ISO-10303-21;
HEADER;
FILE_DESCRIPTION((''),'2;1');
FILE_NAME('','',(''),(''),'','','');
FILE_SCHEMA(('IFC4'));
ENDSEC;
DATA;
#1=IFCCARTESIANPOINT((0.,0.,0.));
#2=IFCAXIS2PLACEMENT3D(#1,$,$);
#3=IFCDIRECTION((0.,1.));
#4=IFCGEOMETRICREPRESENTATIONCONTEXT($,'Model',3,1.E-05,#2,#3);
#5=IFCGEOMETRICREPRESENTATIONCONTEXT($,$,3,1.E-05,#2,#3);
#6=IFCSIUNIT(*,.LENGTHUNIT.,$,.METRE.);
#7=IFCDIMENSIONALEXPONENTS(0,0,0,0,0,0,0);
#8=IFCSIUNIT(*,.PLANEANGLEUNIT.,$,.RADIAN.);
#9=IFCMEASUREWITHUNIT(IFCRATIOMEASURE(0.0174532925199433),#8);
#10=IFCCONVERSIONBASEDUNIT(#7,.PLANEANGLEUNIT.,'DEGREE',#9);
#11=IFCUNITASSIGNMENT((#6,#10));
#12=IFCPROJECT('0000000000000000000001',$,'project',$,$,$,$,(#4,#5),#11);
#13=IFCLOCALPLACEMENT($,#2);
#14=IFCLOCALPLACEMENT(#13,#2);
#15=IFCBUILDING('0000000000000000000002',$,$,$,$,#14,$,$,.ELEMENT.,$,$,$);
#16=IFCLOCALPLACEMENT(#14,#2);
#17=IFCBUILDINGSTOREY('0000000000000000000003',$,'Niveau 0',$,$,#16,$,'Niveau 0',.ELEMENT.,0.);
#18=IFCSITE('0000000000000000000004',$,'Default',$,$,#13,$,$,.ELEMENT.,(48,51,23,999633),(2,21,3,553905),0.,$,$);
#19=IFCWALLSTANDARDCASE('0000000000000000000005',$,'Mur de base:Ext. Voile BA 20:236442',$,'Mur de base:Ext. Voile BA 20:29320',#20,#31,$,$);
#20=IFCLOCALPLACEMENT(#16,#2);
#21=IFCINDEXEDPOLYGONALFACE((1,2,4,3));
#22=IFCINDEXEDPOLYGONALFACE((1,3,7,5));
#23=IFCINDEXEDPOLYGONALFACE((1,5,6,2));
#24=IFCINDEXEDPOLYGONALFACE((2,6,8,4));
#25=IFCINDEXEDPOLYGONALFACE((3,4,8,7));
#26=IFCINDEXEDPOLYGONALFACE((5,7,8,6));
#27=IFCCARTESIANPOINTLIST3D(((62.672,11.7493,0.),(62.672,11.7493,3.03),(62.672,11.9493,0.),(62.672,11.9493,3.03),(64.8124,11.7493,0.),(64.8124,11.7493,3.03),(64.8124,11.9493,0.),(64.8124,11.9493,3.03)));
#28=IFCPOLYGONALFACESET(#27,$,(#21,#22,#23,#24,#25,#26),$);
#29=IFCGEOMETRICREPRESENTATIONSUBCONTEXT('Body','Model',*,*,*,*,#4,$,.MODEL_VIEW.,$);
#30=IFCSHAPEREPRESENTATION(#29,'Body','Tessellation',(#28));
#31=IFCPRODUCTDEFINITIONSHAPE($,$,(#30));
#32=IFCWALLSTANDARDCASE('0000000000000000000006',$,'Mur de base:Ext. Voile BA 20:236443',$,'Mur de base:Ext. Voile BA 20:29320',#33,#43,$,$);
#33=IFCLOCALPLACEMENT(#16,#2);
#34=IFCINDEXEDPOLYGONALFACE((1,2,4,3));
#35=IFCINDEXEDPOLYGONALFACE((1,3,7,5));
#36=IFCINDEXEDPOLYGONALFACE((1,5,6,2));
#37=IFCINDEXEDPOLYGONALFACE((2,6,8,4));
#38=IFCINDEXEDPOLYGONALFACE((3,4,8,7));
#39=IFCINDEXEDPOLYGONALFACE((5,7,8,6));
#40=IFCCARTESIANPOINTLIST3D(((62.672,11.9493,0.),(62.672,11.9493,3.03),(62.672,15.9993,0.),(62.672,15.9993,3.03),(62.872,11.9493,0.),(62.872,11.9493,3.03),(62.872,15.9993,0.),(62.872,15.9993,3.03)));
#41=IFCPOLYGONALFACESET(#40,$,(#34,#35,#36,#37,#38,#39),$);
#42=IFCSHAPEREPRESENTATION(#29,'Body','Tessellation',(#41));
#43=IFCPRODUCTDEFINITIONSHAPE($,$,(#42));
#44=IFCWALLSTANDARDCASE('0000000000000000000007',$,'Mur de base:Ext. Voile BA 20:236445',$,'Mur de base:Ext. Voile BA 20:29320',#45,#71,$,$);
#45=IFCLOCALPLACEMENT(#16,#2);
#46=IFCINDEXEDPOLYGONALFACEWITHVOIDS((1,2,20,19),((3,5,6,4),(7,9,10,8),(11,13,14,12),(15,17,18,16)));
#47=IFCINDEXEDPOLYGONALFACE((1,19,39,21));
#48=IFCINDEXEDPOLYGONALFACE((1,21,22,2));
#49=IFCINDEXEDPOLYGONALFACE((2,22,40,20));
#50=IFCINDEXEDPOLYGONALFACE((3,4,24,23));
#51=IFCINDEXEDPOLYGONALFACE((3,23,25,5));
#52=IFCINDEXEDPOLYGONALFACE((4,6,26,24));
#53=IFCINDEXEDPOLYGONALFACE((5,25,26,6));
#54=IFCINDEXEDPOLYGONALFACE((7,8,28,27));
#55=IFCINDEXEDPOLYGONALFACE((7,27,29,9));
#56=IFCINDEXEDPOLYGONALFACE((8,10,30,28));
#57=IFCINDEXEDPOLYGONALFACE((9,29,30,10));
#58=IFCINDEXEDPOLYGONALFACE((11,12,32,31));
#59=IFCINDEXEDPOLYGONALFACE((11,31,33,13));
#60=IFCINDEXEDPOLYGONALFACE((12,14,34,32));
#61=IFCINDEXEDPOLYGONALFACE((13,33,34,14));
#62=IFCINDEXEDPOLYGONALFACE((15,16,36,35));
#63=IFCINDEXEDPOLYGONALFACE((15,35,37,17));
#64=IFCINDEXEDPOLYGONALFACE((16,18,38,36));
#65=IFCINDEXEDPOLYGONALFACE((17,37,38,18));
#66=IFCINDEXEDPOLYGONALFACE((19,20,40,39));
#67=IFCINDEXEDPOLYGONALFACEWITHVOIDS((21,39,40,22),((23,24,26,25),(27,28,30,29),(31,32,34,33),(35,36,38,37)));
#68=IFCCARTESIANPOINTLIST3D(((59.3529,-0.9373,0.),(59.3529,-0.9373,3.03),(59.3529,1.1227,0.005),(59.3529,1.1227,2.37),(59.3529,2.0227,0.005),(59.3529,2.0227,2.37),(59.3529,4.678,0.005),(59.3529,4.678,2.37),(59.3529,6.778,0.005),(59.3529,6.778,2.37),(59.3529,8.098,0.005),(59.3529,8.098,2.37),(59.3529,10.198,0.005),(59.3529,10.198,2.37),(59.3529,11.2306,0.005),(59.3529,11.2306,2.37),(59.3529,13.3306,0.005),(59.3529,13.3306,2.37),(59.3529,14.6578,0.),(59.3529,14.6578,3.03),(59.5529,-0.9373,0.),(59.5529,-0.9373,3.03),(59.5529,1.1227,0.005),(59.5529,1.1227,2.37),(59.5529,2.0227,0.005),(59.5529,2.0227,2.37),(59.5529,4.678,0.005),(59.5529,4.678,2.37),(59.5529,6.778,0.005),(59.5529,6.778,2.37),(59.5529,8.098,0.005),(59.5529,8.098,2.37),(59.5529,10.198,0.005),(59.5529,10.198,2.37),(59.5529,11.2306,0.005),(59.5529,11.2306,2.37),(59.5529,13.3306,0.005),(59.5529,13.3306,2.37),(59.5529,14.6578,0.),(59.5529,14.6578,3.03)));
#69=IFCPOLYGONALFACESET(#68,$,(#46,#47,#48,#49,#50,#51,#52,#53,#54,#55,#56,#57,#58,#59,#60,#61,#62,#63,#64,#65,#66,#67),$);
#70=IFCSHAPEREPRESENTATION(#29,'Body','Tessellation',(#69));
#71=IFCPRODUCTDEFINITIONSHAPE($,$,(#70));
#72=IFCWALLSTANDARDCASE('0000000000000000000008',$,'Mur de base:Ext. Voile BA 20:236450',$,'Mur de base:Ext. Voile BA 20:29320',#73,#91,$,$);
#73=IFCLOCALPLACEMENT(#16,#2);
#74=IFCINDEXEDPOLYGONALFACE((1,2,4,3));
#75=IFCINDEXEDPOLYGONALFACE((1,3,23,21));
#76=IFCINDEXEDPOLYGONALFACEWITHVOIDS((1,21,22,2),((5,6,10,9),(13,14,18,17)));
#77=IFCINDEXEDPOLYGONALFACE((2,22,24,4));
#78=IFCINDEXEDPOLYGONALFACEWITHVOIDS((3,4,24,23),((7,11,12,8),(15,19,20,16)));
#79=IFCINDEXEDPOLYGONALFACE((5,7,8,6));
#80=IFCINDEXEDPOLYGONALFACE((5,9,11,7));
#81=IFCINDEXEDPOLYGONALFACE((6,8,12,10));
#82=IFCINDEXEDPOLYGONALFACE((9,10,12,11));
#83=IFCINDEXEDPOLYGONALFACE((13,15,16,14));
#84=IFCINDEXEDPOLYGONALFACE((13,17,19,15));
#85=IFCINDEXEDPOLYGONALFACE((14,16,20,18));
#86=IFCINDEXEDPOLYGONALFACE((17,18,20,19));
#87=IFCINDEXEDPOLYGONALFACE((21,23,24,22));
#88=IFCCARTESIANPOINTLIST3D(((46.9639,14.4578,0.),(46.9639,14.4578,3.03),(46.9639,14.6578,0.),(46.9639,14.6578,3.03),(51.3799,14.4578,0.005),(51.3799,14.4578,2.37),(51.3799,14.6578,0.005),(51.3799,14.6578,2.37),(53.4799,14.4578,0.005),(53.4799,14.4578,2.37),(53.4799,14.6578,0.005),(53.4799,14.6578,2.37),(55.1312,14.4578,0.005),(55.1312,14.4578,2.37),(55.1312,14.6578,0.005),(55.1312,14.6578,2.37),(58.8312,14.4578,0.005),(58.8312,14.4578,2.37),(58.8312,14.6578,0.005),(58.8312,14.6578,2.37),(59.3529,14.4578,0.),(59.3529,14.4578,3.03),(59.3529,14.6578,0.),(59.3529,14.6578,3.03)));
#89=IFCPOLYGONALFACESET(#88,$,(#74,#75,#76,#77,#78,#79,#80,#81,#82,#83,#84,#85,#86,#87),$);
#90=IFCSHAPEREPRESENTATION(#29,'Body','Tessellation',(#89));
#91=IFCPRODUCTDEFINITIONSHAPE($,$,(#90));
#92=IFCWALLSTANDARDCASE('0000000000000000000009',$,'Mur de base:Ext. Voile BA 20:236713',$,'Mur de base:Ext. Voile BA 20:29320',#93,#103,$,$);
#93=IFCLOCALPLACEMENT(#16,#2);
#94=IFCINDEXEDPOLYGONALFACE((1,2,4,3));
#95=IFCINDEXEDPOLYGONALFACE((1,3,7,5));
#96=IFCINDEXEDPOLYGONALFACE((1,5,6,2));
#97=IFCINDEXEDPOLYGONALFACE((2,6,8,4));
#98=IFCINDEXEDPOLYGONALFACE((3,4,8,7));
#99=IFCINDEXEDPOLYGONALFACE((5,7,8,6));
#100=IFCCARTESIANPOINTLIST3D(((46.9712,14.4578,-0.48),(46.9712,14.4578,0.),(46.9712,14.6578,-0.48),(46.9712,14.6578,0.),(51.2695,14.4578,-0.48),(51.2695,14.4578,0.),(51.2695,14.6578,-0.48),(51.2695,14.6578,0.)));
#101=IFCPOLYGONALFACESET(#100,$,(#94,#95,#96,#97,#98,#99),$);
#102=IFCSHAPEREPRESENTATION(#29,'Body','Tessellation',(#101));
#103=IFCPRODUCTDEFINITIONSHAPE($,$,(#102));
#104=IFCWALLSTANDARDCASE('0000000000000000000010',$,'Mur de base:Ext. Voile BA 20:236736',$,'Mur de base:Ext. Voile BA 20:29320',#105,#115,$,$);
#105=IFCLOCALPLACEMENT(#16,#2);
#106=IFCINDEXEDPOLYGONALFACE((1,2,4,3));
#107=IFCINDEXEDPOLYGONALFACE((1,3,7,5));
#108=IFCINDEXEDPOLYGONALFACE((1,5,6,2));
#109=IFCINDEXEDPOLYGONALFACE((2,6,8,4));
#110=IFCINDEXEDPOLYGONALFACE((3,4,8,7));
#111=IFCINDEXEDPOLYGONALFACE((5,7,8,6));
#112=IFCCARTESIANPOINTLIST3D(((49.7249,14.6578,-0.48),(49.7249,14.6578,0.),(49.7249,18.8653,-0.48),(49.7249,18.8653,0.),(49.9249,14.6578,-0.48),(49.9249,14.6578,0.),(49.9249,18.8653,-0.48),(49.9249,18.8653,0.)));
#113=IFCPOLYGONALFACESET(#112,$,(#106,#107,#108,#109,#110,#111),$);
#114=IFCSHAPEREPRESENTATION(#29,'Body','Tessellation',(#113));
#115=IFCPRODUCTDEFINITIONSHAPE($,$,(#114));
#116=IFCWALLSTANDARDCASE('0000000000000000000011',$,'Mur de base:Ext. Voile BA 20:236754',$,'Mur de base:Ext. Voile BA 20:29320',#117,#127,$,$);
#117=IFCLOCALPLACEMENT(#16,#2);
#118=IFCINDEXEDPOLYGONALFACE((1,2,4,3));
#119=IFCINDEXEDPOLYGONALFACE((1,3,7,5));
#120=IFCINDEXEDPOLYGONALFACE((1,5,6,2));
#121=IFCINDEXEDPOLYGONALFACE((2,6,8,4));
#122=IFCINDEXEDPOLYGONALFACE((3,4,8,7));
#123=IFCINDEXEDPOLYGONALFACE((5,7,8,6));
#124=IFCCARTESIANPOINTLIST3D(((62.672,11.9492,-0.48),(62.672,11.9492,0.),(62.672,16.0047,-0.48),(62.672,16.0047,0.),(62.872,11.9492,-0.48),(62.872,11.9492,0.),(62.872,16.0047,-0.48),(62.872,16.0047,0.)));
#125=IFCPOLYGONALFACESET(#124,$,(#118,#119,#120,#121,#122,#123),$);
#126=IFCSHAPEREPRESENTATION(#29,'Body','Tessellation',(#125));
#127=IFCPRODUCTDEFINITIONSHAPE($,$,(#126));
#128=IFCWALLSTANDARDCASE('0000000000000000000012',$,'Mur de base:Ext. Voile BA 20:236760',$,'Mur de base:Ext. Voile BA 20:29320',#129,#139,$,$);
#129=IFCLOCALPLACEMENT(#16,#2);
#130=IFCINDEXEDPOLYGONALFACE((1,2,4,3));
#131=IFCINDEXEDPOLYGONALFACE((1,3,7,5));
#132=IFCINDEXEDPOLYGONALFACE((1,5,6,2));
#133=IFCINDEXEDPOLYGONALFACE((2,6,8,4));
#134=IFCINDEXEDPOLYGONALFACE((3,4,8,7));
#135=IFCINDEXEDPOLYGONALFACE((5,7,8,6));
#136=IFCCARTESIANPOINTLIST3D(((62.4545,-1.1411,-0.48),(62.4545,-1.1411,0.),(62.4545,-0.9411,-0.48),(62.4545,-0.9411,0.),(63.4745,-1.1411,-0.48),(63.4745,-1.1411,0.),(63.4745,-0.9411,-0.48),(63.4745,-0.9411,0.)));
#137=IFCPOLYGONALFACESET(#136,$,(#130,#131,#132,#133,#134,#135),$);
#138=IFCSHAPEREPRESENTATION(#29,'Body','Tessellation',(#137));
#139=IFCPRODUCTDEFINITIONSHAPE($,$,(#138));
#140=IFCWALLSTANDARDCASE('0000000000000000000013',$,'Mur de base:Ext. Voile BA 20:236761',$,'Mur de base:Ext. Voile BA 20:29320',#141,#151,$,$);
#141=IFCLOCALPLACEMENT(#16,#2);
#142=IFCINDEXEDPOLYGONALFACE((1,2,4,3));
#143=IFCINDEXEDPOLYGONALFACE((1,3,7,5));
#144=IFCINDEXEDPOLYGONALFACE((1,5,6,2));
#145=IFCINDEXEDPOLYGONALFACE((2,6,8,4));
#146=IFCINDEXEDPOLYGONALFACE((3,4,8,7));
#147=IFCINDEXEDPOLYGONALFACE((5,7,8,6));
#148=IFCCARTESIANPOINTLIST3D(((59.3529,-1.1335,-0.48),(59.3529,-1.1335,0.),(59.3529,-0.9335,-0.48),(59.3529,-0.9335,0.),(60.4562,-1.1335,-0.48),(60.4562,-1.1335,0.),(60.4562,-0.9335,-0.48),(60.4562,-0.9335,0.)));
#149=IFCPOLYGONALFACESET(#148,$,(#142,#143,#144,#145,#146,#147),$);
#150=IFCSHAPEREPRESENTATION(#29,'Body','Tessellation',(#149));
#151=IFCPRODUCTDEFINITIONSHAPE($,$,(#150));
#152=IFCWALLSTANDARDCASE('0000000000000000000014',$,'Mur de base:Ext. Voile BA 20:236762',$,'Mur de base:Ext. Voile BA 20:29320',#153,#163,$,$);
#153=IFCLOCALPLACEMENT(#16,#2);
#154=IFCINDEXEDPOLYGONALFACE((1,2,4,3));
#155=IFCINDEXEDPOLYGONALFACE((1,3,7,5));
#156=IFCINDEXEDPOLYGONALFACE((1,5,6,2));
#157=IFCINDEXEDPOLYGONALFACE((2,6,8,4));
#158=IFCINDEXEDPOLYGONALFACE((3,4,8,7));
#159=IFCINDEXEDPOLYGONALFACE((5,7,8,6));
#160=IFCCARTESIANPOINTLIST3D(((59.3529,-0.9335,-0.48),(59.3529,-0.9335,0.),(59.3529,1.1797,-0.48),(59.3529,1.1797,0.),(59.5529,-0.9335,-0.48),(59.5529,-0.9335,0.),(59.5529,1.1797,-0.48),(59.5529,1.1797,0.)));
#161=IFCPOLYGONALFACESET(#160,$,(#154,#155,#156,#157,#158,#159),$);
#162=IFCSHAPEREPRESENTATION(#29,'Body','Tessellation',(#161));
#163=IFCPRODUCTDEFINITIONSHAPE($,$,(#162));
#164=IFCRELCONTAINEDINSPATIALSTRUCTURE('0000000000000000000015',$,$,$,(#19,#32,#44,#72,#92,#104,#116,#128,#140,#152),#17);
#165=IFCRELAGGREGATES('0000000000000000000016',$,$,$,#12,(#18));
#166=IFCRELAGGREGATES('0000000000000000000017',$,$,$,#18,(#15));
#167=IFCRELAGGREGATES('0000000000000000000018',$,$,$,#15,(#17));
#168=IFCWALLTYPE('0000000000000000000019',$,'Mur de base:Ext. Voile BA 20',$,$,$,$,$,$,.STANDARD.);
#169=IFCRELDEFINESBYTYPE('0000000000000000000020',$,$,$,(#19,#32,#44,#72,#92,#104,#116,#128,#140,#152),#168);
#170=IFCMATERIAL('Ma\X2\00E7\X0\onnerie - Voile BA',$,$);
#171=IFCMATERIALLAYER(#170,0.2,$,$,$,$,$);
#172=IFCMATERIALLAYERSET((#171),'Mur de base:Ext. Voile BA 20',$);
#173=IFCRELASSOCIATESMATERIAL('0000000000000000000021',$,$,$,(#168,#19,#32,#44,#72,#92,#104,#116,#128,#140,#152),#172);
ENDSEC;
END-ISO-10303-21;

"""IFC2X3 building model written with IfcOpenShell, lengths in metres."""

from ifc_helpers import new_model, entity, si_unit, converted_unit, direction, frame, frame_2d, origin, origin_2d_with_axis, place, context, subcontext, project, spatial, rectangle, extrude, material, layer, layer_set, layer_usage, type_object, element, save


model = new_model("IFC2X3")

# Units and contexts
model_context = context("Model", 3, precision=1e-05, world=origin(), true_north=direction((0.0, 1.0)))
context_of_model = context(None, 3, precision=1e-05, world=origin(), true_north=direction((0.0, 1.0)))
body_context = subcontext(model_context, "Body", "Model", "MODEL_VIEW")
ifc_project = project(units=[si_unit("LENGTHUNIT", "METRE"), converted_unit("PLANEANGLEUNIT", "DEGREE", entity("IfcRatioMeasure", 0.0174532925199433), si_unit("PLANEANGLEUNIT", "RADIAN"), dimensions=[0, 0, 0, 0, 0, 0, 0])], contexts=[model_context, context_of_model])

# Site, building, storey
site_placement = place(None, origin())
site = spatial("IfcSite", under=ifc_project, at=site_placement, Name="Default", CompositionType="ELEMENT", RefLatitude=(48, 51, 23, 999633), RefLongitude=(2, 21, 3, 553905), RefElevation=0.0)
building_placement = place(site_placement, origin())
building = spatial("IfcBuilding", under=site, at=building_placement, CompositionType="ELEMENT")
storey_placement = place(building_placement, origin())
storey = spatial("IfcBuildingStorey", under=building, at=storey_placement, Name="Niveau 0", LongName="Niveau 0", CompositionType="ELEMENT", Elevation=0.0)

# Walls
ifc_material = material(Name="Maçonnerie - Voile BA")
ifc_layer = layer(ifc_material, 0.2)
ifc_layer_set = layer_set([ifc_layer], Name="Mur de base:Ext. Voile BA 20")
ifc_layer_usage_1 = layer_usage(ifc_layer_set, "AXIS2", "NEGATIVE", 0.1)
wall_type = type_object("IfcWallType", Name="Mur de base:Ext. Voile BA 20", PredefinedType="STANDARD", material=ifc_layer_set)
wall_1_placement = place(storey_placement, frame((64.8124, 11.8493, 0.0), z_axis=(0.0, 0.0, 1.0), x_axis=(-1.0, 0.0, 0.0)))
element("IfcWallStandardCase", 1, at=wall_1_placement, inside=storey, type_object=wall_type, material=ifc_layer_usage_1, Name="Mur de base:Ext. Voile BA 20:236442", ObjectType="Mur de base:Ext. Voile BA 20:29320", context=body_context, shape_type="SweptSolid", body=[
    extrude(rectangle(XDim=2.1404, YDim=0.2, at=frame_2d((1.0702, 0.0), x_axis=(-1.0, 0.0))), origin(), (0.0, 0.0, 1.0), 3.03),
])
ifc_layer_usage_2 = layer_usage(ifc_layer_set, "AXIS2", "NEGATIVE", 0.1)
wall_2_placement = place(storey_placement, frame((62.772, 11.9493, 0.0), z_axis=(0.0, 0.0, 1.0), x_axis=(0.0, 1.0, 0.0)))
element("IfcWallStandardCase", 2, at=wall_2_placement, inside=storey, type_object=wall_type, material=ifc_layer_usage_2, Name="Mur de base:Ext. Voile BA 20:236443", ObjectType="Mur de base:Ext. Voile BA 20:29320", context=body_context, shape_type="SweptSolid", body=[
    extrude(rectangle(XDim=4.05, YDim=0.2, at=frame_2d((2.025, 0.0), x_axis=(-1.0, 0.0))), origin(), (0.0, 0.0, 1.0), 3.03),
])

# Walls, openings
ifc_layer_usage_3 = layer_usage(ifc_layer_set, "AXIS2", "NEGATIVE", 0.1)
wall_3_placement = place(storey_placement, frame((59.4529, -0.9373, 0.0), z_axis=(0.0, 0.0, 1.0), x_axis=(0.0, 1.0, 0.0)))
wall_3 = element("IfcWallStandardCase", 3, at=wall_3_placement, inside=storey, type_object=wall_type, material=ifc_layer_usage_3, Name="Mur de base:Ext. Voile BA 20:236445", ObjectType="Mur de base:Ext. Voile BA 20:29320", context=body_context, shape_type="SweptSolid", body=[
    extrude(rectangle(XDim=15.5951, YDim=0.2, at=frame_2d((7.7976, 0.0), x_axis=(-1.0, 0.0))), origin(), (0.0, 0.0, 1.0), 3.03),
])
opening_1_placement = place(wall_3_placement, origin())
element("IfcOpeningElement", 4, at=opening_1_placement, cuts=wall_3, ObjectType="Opening", context=body_context, shape_type="SweptSolid", body=[
    extrude(rectangle(XDim=2.365, YDim=0.9, at=frame_2d((0.0, 0.0), x_axis=(1.0, 0.0))), frame((2.51, -0.1, 1.1875), z_axis=(0.0, 1.0, 0.0), x_axis=(0.0, 0.0, -1.0)), (0.0, 0.0, 1.0), 0.2),
])
opening_2_placement = place(wall_3_placement, origin())
element("IfcOpeningElement", 5, at=opening_2_placement, cuts=wall_3, ObjectType="Opening", context=body_context, shape_type="SweptSolid", body=[
    extrude(rectangle(XDim=2.365, YDim=2.1, at=origin_2d_with_axis()), frame((6.6653, -0.1, 1.1875), z_axis=(0.0, 1.0, 0.0), x_axis=(0.0, 0.0, -1.0)), (0.0, 0.0, 1.0), 0.2),
])
opening_3_placement = place(wall_3_placement, origin())
element("IfcOpeningElement", 6, at=opening_3_placement, cuts=wall_3, ObjectType="Opening", context=body_context, shape_type="SweptSolid", body=[
    extrude(rectangle(XDim=2.365, YDim=2.1, at=origin_2d_with_axis()), frame((10.0853, -0.1, 1.1875), z_axis=(0.0, 1.0, 0.0), x_axis=(0.0, 0.0, -1.0)), (0.0, 0.0, 1.0), 0.2),
])
opening_4_placement = place(wall_3_placement, origin())
element("IfcOpeningElement", 7, at=opening_4_placement, cuts=wall_3, ObjectType="Opening", context=body_context, shape_type="SweptSolid", body=[
    extrude(rectangle(XDim=2.365, YDim=2.1, at=origin_2d_with_axis()), frame((13.2179, -0.1, 1.1875), z_axis=(0.0, 1.0, 0.0), x_axis=(0.0, 0.0, -1.0)), (0.0, 0.0, 1.0), 0.2),
])
ifc_layer_usage_4 = layer_usage(ifc_layer_set, "AXIS2", "NEGATIVE", 0.1)
wall_4_placement = place(storey_placement, frame((59.3529, 14.5578, 0.0), z_axis=(0.0, 0.0, 1.0), x_axis=(-1.0, 0.0, 0.0)))
wall_4 = element("IfcWallStandardCase", 8, at=wall_4_placement, inside=storey, type_object=wall_type, material=ifc_layer_usage_4, Name="Mur de base:Ext. Voile BA 20:236450", ObjectType="Mur de base:Ext. Voile BA 20:29320", context=body_context, shape_type="SweptSolid", body=[
    extrude(rectangle(XDim=12.389, YDim=0.2, at=frame_2d((6.1945, 0.0), x_axis=(-1.0, 0.0))), origin(), (0.0, 0.0, 1.0), 3.03),
])
opening_5_placement = place(wall_4_placement, origin())
element("IfcOpeningElement", 9, at=opening_5_placement, cuts=wall_4, ObjectType="Opening", context=body_context, shape_type="SweptSolid", body=[
    extrude(rectangle(XDim=2.365, YDim=2.1, at=frame_2d((0.0, 0.0), x_axis=(1.0, 0.0))), frame((6.923, -0.1, 1.1875), z_axis=(0.0, 1.0, 0.0), x_axis=(0.0, 0.0, -1.0)), (0.0, 0.0, 1.0), 0.2),
])
opening_6_placement = place(wall_4_placement, origin())
element("IfcOpeningElement", 10, at=opening_6_placement, cuts=wall_4, ObjectType="Opening", context=body_context, shape_type="SweptSolid", body=[
    extrude(rectangle(XDim=2.365, YDim=3.7, at=frame_2d((0.0, 0.0), x_axis=(1.0, 0.0))), frame((2.3717, -0.1, 1.1875), z_axis=(0.0, 1.0, 0.0), x_axis=(0.0, 0.0, -1.0)), (0.0, 0.0, 1.0), 0.2),
])

# Walls
ifc_layer_usage_5 = layer_usage(ifc_layer_set, "AXIS2", "NEGATIVE", 0.1)
wall_5_placement = place(storey_placement, frame((51.2695, 14.5578, -0.48), z_axis=(0.0, 0.0, 1.0), x_axis=(-1.0, 0.0, 0.0)))
element("IfcWallStandardCase", 11, at=wall_5_placement, inside=storey, type_object=wall_type, material=ifc_layer_usage_5, Name="Mur de base:Ext. Voile BA 20:236713", ObjectType="Mur de base:Ext. Voile BA 20:29320", context=body_context, shape_type="SweptSolid", body=[
    extrude(rectangle(XDim=4.2983, YDim=0.2, at=frame_2d((2.1491, 0.0), x_axis=(-1.0, 0.0))), origin(), (0.0, 0.0, 1.0), 0.48),
])
ifc_layer_usage_6 = layer_usage(ifc_layer_set, "AXIS2", "NEGATIVE", 0.1)
wall_6_placement = place(storey_placement, frame((49.8249, 14.6578, -0.48), z_axis=(0.0, 0.0, 1.0), x_axis=(0.0, 1.0, 0.0)))
element("IfcWallStandardCase", 12, at=wall_6_placement, inside=storey, type_object=wall_type, material=ifc_layer_usage_6, Name="Mur de base:Ext. Voile BA 20:236736", ObjectType="Mur de base:Ext. Voile BA 20:29320", context=body_context, shape_type="SweptSolid", body=[
    extrude(rectangle(XDim=4.2074, YDim=0.2, at=frame_2d((2.1037, 0.0), x_axis=(-1.0, 0.0))), origin(), (0.0, 0.0, 1.0), 0.48),
])
ifc_layer_usage_7 = layer_usage(ifc_layer_set, "AXIS2", "NEGATIVE", 0.1)
wall_7_placement = place(storey_placement, frame((62.772, 11.9492, -0.48), z_axis=(0.0, 0.0, 1.0), x_axis=(0.0, 1.0, 0.0)))
element("IfcWallStandardCase", 13, at=wall_7_placement, inside=storey, type_object=wall_type, material=ifc_layer_usage_7, Name="Mur de base:Ext. Voile BA 20:236754", ObjectType="Mur de base:Ext. Voile BA 20:29320", context=body_context, shape_type="SweptSolid", body=[
    extrude(rectangle(XDim=4.0555, YDim=0.2, at=frame_2d((2.0278, 0.0), x_axis=(-1.0, 0.0))), origin(), (0.0, 0.0, 1.0), 0.48),
])
ifc_layer_usage_8 = layer_usage(ifc_layer_set, "AXIS2", "NEGATIVE", 0.1)
wall_8_placement = place(storey_placement, frame((63.4745, -1.0411, -0.48), z_axis=(0.0, 0.0, 1.0), x_axis=(-1.0, 0.0, 0.0)))
element("IfcWallStandardCase", 14, at=wall_8_placement, inside=storey, type_object=wall_type, material=ifc_layer_usage_8, Name="Mur de base:Ext. Voile BA 20:236760", ObjectType="Mur de base:Ext. Voile BA 20:29320", context=body_context, shape_type="SweptSolid", body=[
    extrude(rectangle(XDim=1.02, YDim=0.2, at=frame_2d((0.51, 0.0), x_axis=(-1.0, 0.0))), origin(), (0.0, 0.0, 1.0), 0.48),
])
ifc_layer_usage_9 = layer_usage(ifc_layer_set, "AXIS2", "NEGATIVE", 0.1)
wall_9_placement = place(storey_placement, frame((60.4562, -1.0335, -0.48), z_axis=(0.0, 0.0, 1.0), x_axis=(-1.0, 0.0, 0.0)))
element("IfcWallStandardCase", 15, at=wall_9_placement, inside=storey, type_object=wall_type, material=ifc_layer_usage_9, Name="Mur de base:Ext. Voile BA 20:236761", ObjectType="Mur de base:Ext. Voile BA 20:29320", context=body_context, shape_type="SweptSolid", body=[
    extrude(rectangle(XDim=1.1033, YDim=0.2, at=frame_2d((0.5516, 0.0), x_axis=(-1.0, 0.0))), origin(), (0.0, 0.0, 1.0), 0.48),
])
ifc_layer_usage_10 = layer_usage(ifc_layer_set, "AXIS2", "NEGATIVE", 0.1)
wall_10_placement = place(storey_placement, frame((59.4529, -0.9335, -0.48), z_axis=(0.0, 0.0, 1.0), x_axis=(0.0, 1.0, 0.0)))
element("IfcWallStandardCase", 16, at=wall_10_placement, inside=storey, type_object=wall_type, material=ifc_layer_usage_10, Name="Mur de base:Ext. Voile BA 20:236762", ObjectType="Mur de base:Ext. Voile BA 20:29320", context=body_context, shape_type="SweptSolid", body=[
    extrude(rectangle(XDim=2.1132, YDim=0.2, at=frame_2d((1.0566, 0.0), x_axis=(-1.0, 0.0))), origin(), (0.0, 0.0, 1.0), 0.48),
])

save(model, "model.ifc")
